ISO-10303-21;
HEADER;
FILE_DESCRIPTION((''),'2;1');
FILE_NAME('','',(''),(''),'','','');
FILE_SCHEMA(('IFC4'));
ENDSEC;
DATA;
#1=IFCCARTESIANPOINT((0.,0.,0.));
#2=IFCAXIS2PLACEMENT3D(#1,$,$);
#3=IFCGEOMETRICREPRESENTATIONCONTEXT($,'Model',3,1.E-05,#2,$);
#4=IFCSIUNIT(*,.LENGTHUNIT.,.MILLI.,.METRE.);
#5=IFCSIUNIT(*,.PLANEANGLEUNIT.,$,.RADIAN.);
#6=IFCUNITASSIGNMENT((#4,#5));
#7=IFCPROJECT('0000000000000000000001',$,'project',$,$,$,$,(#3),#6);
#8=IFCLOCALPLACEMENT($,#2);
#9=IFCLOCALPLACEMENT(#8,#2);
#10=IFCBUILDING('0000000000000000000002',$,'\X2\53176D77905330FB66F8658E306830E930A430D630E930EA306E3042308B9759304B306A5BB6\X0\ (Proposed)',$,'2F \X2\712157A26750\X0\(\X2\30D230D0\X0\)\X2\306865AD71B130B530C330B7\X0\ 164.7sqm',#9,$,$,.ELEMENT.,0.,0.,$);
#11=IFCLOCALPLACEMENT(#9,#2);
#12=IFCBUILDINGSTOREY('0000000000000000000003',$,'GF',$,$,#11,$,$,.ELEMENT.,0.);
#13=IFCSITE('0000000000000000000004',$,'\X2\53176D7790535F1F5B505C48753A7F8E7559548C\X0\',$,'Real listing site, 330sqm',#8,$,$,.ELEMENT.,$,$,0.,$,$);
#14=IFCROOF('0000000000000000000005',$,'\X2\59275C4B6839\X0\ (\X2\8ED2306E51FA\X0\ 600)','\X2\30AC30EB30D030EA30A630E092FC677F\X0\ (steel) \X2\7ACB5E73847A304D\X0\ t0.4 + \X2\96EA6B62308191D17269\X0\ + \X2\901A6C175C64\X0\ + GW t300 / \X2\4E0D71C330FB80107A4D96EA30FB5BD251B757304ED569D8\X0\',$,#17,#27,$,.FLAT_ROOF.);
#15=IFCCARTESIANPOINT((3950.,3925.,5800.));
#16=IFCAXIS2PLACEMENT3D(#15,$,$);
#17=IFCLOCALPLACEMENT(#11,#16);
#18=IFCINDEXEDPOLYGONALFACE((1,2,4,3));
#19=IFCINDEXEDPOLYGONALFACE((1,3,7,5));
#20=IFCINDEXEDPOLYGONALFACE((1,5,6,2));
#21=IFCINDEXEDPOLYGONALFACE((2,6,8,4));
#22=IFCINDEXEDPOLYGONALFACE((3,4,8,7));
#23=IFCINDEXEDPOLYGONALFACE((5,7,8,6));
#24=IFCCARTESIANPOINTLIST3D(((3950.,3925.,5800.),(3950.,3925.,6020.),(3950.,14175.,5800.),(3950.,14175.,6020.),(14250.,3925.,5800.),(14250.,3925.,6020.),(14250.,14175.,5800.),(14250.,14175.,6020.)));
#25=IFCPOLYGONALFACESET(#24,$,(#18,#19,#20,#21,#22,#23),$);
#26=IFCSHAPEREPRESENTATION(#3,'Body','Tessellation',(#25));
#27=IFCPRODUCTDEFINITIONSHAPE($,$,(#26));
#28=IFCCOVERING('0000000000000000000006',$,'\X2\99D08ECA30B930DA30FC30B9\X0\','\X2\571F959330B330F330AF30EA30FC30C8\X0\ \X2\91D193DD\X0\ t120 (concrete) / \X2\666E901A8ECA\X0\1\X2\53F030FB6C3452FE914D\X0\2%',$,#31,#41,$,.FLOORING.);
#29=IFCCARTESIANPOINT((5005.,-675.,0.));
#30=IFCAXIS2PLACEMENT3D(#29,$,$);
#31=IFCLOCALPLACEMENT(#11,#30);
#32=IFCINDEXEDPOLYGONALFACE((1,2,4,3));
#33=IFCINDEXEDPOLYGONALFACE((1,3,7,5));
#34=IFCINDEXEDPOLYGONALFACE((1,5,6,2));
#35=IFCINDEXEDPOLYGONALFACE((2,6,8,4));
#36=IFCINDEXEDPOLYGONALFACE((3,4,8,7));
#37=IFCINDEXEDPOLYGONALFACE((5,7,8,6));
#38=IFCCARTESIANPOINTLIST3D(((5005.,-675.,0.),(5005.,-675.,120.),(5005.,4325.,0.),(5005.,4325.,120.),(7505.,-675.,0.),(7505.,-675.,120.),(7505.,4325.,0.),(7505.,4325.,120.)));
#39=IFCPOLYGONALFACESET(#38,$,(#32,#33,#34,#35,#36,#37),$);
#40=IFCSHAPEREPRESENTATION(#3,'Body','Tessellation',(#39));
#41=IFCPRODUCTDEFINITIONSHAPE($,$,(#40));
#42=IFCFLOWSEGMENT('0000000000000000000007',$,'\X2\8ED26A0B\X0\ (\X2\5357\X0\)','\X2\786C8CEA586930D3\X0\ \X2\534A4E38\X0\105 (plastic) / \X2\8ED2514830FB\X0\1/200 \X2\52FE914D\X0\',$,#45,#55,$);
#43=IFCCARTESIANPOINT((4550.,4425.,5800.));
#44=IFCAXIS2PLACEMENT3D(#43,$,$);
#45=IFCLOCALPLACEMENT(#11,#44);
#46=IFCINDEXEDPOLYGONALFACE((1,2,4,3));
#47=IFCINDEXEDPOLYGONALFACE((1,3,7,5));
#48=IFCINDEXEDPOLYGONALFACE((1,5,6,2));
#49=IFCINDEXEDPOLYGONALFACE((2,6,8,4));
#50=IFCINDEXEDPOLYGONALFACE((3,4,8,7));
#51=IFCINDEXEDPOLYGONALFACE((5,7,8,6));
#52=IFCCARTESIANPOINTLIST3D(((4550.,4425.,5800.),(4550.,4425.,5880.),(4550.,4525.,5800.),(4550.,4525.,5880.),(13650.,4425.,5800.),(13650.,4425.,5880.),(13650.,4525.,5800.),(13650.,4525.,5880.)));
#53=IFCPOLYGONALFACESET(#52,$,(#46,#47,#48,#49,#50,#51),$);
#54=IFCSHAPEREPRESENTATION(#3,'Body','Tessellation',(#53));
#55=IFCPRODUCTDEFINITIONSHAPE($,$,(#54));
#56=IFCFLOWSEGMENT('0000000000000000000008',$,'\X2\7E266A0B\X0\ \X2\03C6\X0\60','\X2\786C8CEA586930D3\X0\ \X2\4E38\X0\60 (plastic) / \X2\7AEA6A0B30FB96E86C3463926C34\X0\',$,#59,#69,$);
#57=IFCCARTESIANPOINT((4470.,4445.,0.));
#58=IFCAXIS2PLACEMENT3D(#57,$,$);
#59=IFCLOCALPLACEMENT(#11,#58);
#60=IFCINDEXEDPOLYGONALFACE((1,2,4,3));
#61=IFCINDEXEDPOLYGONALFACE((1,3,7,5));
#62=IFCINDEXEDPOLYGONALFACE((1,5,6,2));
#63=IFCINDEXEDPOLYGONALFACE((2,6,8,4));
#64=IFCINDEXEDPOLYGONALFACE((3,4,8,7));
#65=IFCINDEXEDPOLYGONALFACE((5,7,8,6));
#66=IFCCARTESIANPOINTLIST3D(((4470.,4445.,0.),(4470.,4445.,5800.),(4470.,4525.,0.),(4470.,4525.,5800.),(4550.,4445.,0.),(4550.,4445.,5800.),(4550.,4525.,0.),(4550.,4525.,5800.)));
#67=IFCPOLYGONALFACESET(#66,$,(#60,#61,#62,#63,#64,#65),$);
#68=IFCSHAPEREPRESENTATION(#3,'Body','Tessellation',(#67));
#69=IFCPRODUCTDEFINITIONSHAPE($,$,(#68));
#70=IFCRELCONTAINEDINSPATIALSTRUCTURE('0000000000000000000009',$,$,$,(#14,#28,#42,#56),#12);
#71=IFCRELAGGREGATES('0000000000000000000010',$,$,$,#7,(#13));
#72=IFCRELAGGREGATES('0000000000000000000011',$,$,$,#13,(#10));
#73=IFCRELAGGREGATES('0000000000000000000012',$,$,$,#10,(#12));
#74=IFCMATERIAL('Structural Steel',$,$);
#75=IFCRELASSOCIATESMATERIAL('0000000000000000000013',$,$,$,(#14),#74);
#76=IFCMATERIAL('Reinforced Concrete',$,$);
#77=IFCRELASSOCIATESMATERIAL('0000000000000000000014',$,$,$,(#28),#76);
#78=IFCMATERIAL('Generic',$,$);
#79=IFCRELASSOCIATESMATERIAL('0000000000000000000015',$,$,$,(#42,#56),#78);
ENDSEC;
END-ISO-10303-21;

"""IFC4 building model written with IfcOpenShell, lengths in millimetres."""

from ifc_helpers import new_model, si_unit, frame, frame_2d, origin, place, context, project, spatial, rectangle, extrude, material, element, save


model = new_model("IFC4")

# Units and contexts
model_context = context("Model", 3, precision=1e-05, world=origin())
ifc_project = project(units=[si_unit("LENGTHUNIT", "METRE", prefix="MILLI"), si_unit("PLANEANGLEUNIT", "RADIAN")], contexts=[model_context])

# Site, building, storey
site_placement = place(None, origin())
site = spatial("IfcSite", under=ifc_project, at=site_placement, Name="北海道弟子屈町美留和", ObjectType="Real listing site, 330sqm", CompositionType="ELEMENT", RefElevation=0.0)
building_placement = place(site_placement, origin())
building = spatial("IfcBuilding", under=site, at=building_placement, Name="北海道・書斎とライブラリのある静かな家 (Proposed)", ObjectType="2F 無垢材(ヒバ)と断熱サッシ 164.7sqm", CompositionType="ELEMENT", ElevationOfRefHeight=0.0, ElevationOfTerrain=0.0)
storey_placement = place(building_placement, origin())
storey = spatial("IfcBuildingStorey", under=building, at=storey_placement, Name="GF", CompositionType="ELEMENT", Elevation=0.0)

# Shared definitions
ifc_material_1 = material(Name="Reinforced Concrete")

# Roof
ifc_material_2 = material(Name="Structural Steel")
roof_placement = place(storey_placement, frame((3950.0, 3925.0, 5800.0)))
element("IfcRoof", 1, at=roof_placement, inside=storey, material=ifc_material_2, Name="大屋根 (軒の出 600)", Description="ガルバリウム鋼板 (steel) 立平葺き t0.4 + 雪止め金物 + 通気層 + GW t300 / 不燃・耐積雪・寒冷地仕様", PredefinedType="FLAT_ROOF", context=model_context, shape_type="SweptSolid", body=[
    extrude(rectangle(XDim=10300.0, YDim=10250.0, at=frame_2d((5150.0, 5125.0))), frame((3950.0, 3925.0, 5800.0)), (0.0, 0.0, 1.0), 220.0),
])

# Covering
covering_placement = place(storey_placement, frame((5005.0, -675.0, 0.0)))
element("IfcCovering", 2, at=covering_placement, inside=storey, material=ifc_material_1, Name="駐車スペース", Description="土間コンクリート 金鏝 t120 (concrete) / 普通車1台・水勾配2%", PredefinedType="FLOORING", context=model_context, shape_type="SweptSolid", body=[
    extrude(rectangle(XDim=2500.0, YDim=5000.0, at=frame_2d((1250.0, 2500.0))), frame((5005.0, -675.0, 0.0)), (0.0, 0.0, 1.0), 120.0),
])

# Flow segments
ifc_material_3 = material(Name="Generic")
flow_segment_1_placement = place(storey_placement, frame((4550.0, 4425.0, 5800.0)))
element("IfcFlowSegment", 3, at=flow_segment_1_placement, inside=storey, material=ifc_material_3, Name="軒樋 (南)", Description="硬質塩ビ 半丸105 (plastic) / 軒先・1/200 勾配", context=model_context, shape_type="SweptSolid", body=[
    extrude(rectangle(XDim=9100.0, YDim=100.0, at=frame_2d((4550.0, 50.0))), frame((4550.0, 4425.0, 5800.0)), (0.0, 0.0, 1.0), 80.0),
])
flow_segment_2_placement = place(storey_placement, frame((4470.0, 4445.0, 0.0)))
element("IfcFlowSegment", 4, at=flow_segment_2_placement, inside=storey, material=ifc_material_3, Name="縦樋 φ60", Description="硬質塩ビ 丸60 (plastic) / 竪樋・雨水排水", context=model_context, shape_type="SweptSolid", body=[
    extrude(rectangle(XDim=80.0, YDim=80.0, at=frame_2d((40.0, 40.0))), frame((4470.0, 4445.0, 0.0)), (0.0, 0.0, 1.0), 5800.0),
])

save(model, "model.ifc")
